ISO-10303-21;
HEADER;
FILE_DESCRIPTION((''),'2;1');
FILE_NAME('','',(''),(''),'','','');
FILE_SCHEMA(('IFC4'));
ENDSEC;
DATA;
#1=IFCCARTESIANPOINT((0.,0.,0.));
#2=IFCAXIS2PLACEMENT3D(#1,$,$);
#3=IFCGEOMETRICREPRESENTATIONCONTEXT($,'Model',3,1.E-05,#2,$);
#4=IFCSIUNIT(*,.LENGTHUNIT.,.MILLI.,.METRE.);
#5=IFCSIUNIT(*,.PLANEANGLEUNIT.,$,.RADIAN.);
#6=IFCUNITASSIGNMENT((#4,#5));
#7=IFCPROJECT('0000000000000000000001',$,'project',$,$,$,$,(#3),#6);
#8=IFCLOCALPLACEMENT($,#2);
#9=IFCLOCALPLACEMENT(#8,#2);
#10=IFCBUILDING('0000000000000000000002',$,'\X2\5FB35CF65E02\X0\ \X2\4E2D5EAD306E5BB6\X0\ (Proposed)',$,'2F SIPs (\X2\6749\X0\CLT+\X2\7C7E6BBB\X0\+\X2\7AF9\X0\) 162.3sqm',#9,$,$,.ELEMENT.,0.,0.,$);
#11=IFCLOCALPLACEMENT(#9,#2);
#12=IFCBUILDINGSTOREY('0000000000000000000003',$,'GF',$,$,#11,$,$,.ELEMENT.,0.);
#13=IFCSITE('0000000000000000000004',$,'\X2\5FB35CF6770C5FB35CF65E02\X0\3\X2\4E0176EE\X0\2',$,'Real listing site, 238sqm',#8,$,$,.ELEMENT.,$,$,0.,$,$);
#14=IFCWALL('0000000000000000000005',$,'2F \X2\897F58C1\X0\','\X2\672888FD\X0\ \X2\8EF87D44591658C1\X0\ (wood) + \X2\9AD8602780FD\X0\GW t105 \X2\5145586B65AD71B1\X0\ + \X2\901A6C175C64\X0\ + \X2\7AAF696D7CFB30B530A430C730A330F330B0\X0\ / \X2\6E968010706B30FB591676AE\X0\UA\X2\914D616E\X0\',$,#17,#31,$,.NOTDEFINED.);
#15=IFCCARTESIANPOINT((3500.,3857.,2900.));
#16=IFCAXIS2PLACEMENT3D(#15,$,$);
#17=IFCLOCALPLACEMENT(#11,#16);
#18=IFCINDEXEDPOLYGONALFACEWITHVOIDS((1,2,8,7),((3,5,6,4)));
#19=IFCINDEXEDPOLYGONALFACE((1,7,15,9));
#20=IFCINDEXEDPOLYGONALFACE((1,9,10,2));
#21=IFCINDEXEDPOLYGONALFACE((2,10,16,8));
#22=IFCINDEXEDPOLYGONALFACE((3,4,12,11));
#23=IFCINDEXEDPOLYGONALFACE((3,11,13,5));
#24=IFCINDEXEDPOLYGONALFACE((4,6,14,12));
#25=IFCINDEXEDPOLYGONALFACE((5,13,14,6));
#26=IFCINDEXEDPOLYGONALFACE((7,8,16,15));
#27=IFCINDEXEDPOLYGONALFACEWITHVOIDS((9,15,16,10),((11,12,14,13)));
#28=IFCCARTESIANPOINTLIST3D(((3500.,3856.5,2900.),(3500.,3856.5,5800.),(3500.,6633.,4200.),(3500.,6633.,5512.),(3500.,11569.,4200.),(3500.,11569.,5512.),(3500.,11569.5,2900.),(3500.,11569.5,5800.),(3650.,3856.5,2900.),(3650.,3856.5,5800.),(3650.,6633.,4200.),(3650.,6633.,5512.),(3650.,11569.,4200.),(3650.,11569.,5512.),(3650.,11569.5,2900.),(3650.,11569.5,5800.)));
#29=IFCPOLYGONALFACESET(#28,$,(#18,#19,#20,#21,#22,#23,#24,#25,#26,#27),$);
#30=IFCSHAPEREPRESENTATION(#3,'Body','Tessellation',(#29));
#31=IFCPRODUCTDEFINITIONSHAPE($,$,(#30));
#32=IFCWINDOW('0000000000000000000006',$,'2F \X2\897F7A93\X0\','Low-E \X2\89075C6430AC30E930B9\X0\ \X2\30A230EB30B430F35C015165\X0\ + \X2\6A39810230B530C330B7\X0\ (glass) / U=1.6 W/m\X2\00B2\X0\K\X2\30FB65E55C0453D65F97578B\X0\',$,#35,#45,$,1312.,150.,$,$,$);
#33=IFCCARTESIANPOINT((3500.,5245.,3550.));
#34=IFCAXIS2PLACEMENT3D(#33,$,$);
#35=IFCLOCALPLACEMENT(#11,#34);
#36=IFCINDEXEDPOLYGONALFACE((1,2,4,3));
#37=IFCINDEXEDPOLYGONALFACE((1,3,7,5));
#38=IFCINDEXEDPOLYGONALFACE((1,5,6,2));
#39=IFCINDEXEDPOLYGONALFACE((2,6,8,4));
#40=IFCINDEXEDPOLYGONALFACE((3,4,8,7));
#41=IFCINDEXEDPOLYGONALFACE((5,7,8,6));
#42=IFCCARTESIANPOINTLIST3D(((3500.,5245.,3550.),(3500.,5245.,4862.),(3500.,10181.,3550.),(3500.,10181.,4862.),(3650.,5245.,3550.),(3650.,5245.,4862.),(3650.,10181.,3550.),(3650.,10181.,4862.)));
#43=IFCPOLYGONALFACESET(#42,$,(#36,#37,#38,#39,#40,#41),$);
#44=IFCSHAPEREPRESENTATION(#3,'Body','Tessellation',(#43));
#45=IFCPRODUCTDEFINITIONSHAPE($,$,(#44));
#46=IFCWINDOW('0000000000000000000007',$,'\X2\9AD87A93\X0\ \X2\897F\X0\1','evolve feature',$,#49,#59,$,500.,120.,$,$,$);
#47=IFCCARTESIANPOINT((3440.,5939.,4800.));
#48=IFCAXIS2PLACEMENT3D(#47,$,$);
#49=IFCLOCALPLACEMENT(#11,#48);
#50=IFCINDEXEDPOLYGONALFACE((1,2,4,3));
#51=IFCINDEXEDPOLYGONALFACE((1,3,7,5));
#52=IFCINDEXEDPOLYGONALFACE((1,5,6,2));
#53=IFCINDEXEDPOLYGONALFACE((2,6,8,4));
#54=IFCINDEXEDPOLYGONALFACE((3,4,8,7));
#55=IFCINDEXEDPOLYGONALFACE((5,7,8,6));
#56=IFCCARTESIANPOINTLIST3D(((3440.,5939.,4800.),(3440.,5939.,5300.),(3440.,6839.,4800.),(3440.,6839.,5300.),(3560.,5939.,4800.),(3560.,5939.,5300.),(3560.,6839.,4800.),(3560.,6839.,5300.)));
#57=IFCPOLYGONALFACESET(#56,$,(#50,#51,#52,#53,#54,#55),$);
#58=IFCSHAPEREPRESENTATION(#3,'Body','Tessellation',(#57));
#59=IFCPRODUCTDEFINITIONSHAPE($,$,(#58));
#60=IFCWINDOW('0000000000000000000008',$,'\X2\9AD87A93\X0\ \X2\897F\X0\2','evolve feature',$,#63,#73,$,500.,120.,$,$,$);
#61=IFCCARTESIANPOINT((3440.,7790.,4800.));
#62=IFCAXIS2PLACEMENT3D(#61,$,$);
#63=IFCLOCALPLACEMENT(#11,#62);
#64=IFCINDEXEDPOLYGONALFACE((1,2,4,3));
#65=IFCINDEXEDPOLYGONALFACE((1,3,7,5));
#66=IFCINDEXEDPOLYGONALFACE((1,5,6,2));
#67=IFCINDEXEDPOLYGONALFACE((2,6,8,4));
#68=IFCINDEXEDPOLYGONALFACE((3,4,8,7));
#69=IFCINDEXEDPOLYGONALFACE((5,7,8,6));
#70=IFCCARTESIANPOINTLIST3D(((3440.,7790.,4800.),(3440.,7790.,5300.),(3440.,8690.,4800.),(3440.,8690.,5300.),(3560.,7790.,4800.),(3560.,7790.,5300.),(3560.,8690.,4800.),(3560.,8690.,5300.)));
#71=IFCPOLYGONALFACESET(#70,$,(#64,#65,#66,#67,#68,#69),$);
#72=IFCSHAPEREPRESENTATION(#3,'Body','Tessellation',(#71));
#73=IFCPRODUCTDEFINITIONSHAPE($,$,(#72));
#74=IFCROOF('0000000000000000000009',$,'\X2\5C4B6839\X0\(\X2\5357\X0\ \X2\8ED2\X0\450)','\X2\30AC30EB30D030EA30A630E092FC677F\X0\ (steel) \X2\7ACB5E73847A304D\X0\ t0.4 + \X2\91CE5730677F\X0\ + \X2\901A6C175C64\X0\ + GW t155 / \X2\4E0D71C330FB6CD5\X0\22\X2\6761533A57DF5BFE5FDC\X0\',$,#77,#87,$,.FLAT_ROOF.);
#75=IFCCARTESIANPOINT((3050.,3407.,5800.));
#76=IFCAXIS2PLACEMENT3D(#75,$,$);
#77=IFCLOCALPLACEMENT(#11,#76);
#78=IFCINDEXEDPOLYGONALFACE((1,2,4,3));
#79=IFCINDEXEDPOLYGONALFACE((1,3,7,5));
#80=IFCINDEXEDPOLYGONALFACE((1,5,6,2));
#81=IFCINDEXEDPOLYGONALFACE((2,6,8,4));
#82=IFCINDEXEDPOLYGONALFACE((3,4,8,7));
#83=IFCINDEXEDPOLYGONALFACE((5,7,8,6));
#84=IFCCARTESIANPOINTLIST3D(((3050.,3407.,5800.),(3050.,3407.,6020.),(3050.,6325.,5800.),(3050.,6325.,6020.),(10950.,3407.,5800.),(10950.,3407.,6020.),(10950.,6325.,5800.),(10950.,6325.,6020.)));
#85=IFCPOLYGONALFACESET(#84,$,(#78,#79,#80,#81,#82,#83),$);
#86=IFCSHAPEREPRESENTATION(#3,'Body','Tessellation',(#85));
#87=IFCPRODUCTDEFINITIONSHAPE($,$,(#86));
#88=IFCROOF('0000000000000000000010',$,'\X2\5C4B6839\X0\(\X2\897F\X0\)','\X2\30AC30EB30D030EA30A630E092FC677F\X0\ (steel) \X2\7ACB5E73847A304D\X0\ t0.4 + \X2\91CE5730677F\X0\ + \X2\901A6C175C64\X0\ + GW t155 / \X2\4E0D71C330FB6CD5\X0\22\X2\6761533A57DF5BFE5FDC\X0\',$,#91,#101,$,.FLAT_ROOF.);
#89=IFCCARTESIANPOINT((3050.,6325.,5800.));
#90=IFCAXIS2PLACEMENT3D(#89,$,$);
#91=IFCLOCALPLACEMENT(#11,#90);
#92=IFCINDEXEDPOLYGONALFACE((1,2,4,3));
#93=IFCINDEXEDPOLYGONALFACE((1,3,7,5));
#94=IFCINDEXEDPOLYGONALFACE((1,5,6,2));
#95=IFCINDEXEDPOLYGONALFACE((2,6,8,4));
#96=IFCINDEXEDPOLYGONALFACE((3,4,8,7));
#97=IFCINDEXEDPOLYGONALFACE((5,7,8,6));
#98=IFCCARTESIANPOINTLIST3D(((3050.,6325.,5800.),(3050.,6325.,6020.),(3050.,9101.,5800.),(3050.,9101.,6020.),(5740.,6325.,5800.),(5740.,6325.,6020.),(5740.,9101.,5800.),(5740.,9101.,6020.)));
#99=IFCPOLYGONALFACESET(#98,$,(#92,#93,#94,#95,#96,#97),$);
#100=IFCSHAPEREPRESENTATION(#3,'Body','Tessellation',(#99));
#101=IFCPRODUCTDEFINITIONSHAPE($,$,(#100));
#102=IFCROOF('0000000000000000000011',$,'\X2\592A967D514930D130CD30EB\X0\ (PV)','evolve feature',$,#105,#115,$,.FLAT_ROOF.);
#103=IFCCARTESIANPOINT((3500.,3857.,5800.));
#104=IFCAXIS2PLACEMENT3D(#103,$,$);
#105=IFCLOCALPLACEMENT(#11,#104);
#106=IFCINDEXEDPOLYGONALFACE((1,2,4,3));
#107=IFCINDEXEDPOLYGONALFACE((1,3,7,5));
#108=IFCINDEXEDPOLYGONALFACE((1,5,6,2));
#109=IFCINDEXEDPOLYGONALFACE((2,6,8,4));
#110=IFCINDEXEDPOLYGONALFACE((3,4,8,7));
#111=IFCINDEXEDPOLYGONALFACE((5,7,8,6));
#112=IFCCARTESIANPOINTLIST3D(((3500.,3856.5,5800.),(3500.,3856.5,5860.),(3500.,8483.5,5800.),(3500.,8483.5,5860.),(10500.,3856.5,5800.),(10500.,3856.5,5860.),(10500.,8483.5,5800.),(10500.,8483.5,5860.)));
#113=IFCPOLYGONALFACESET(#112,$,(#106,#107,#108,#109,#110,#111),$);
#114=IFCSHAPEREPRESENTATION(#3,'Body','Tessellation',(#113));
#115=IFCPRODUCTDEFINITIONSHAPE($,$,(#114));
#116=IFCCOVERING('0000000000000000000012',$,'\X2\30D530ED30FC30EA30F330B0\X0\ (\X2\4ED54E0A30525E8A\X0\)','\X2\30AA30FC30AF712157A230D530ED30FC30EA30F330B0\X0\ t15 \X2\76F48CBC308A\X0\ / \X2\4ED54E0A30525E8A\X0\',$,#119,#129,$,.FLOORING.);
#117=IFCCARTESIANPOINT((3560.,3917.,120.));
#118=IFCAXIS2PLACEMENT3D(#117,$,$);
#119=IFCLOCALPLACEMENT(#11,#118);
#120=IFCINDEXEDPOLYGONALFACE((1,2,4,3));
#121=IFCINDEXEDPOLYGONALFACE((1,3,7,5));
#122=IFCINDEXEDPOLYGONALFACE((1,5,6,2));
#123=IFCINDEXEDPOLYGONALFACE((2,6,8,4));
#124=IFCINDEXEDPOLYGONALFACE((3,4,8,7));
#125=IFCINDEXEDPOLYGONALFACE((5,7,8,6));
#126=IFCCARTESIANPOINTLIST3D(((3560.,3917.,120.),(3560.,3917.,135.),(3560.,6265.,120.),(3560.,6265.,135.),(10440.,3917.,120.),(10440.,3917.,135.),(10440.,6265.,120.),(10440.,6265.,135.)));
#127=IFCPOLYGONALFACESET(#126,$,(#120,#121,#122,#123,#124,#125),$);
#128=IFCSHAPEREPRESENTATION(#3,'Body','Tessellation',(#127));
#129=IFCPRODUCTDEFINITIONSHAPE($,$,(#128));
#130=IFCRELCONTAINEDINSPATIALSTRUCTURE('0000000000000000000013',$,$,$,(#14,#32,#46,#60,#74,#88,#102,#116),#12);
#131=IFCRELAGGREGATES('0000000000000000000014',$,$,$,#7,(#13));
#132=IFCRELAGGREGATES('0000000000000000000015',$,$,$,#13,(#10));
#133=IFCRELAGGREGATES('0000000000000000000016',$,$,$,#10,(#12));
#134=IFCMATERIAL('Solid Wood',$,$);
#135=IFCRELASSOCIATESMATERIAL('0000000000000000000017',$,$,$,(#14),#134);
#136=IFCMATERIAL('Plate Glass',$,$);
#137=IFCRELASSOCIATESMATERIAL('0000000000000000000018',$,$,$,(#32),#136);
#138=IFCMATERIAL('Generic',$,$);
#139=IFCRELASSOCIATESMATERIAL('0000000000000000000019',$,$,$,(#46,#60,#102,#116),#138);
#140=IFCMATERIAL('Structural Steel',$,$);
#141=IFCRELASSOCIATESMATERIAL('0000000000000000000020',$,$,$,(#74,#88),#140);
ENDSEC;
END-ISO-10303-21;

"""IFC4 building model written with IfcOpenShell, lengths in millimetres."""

from ifc_helpers import new_model, si_unit, frame, frame_2d, origin, place, context, project, spatial, rectangle, extrude, material, element, fill, save


model = new_model("IFC4")

# Units and contexts
model_context = context("Model", 3, precision=1e-05, world=origin())
ifc_project = project(units=[si_unit("LENGTHUNIT", "METRE", prefix="MILLI"), si_unit("PLANEANGLEUNIT", "RADIAN")], contexts=[model_context])

# Site, building, storey
site_placement = place(None, origin())
site = spatial("IfcSite", under=ifc_project, at=site_placement, Name="徳島県徳島市3丁目2", ObjectType="Real listing site, 238sqm", CompositionType="ELEMENT", RefElevation=0.0)
building_placement = place(site_placement, origin())
building = spatial("IfcBuilding", under=site, at=building_placement, Name="徳島市 中庭の家 (Proposed)", ObjectType="2F SIPs (杉CLT+籾殻+竹) 162.3sqm", CompositionType="ELEMENT", ElevationOfRefHeight=0.0, ElevationOfTerrain=0.0)
storey_placement = place(building_placement, origin())
storey = spatial("IfcBuildingStorey", under=building, at=storey_placement, Name="GF", CompositionType="ELEMENT", Elevation=0.0)

# Shared definitions
ifc_material_1 = material(Name="Solid Wood")
ifc_material_2 = material(Name="Generic")

# Shared definitions
ifc_material_3 = material(Name="Plate Glass")

# Wall, openings, windows
wall_1_placement = place(storey_placement, frame((3500.0, 3857.0, 2900.0)))
wall_1 = element("IfcWall", 1, at=wall_1_placement, inside=storey, material=ifc_material_1, Name="2F 西壁", Description="木製 軸組外壁 (wood) + 高性能GW t105 充填断熱 + 通気層 + 窯業系サイディング / 準耐火・外皮UA配慮", PredefinedType="NOTDEFINED", context=model_context, shape_type="SweptSolid", body=[
    extrude(rectangle(XDim=150.0, YDim=7713.0, at=frame_2d((75.0, 3856.0))), frame((3500.0, 3857.0, 2900.0)), (0.0, 0.0, 1.0), 2900.0),
])
opening_1_placement = place(storey_placement, frame((3500.0, 5245.0, 3550.0)))
opening_1 = element("IfcOpeningElement", 2, at=opening_1_placement, cuts=wall_1, PredefinedType="NOTDEFINED", context=model_context, shape_type="SweptSolid", body=[
    extrude(rectangle(XDim=150.0, YDim=4936.0, at=frame_2d((75.0, 2468.0))), frame((3500.0, 5245.0, 3550.0)), (0.0, 0.0, 1.0), 1312.0),
])
opening_2_placement = place(storey_placement, frame((3440.0, 5939.0, 4800.0)))
opening_2 = element("IfcOpeningElement", 3, at=opening_2_placement, cuts=wall_1, PredefinedType="NOTDEFINED", context=model_context, shape_type="SweptSolid", body=[
    extrude(rectangle(XDim=120.0, YDim=900.0, at=frame_2d((60.0, 450.0))), frame((3440.0, 5939.0, 4800.0)), (0.0, 0.0, 1.0), 500.0),
])
opening_3_placement = place(storey_placement, frame((3440.0, 7790.0, 4800.0)))
opening_3 = element("IfcOpeningElement", 4, at=opening_3_placement, cuts=wall_1, PredefinedType="NOTDEFINED", context=model_context, shape_type="SweptSolid", body=[
    extrude(rectangle(XDim=120.0, YDim=900.0, at=frame_2d((60.0, 450.0))), frame((3440.0, 7790.0, 4800.0)), (0.0, 0.0, 1.0), 500.0),
])
window_1_placement = place(storey_placement, frame((3500.0, 5245.0, 3550.0)))
window_1 = element("IfcWindow", 5, at=window_1_placement, inside=storey, material=ifc_material_3, Name="2F 西窓", Description="Low-E 複層ガラス アルゴン封入 + 樹脂サッシ (glass) / U=1.6 W/m²K・日射取得型", OverallHeight=1312.0, OverallWidth=150.0, context=model_context, shape_type="SweptSolid", body=[
    extrude(rectangle(XDim=150.0, YDim=4936.0, at=frame_2d((75.0, 2468.0))), frame((3500.0, 5245.0, 3550.0)), (0.0, 0.0, 1.0), 1312.0),
])
fill(opening_1, window_1)
window_2_placement = place(storey_placement, frame((3440.0, 5939.0, 4800.0)))
window_2 = element("IfcWindow", 6, at=window_2_placement, inside=storey, material=ifc_material_2, Name="高窓 西1", Description="evolve feature", OverallHeight=500.0, OverallWidth=120.0, context=model_context, shape_type="SweptSolid", body=[
    extrude(rectangle(XDim=120.0, YDim=900.0, at=frame_2d((60.0, 450.0))), frame((3440.0, 5939.0, 4800.0)), (0.0, 0.0, 1.0), 500.0),
])
fill(opening_2, window_2)
window_3_placement = place(storey_placement, frame((3440.0, 7790.0, 4800.0)))
window_3 = element("IfcWindow", 7, at=window_3_placement, inside=storey, material=ifc_material_2, Name="高窓 西2", Description="evolve feature", OverallHeight=500.0, OverallWidth=120.0, context=model_context, shape_type="SweptSolid", body=[
    extrude(rectangle(XDim=120.0, YDim=900.0, at=frame_2d((60.0, 450.0))), frame((3440.0, 7790.0, 4800.0)), (0.0, 0.0, 1.0), 500.0),
])
fill(opening_3, window_3)

# Roofs
ifc_material_4 = material(Name="Structural Steel")
roof_1_placement = place(storey_placement, frame((3050.0, 3407.0, 5800.0)))
element("IfcRoof", 8, at=roof_1_placement, inside=storey, material=ifc_material_4, Name="屋根(南 軒450)", Description="ガルバリウム鋼板 (steel) 立平葺き t0.4 + 野地板 + 通気層 + GW t155 / 不燃・法22条区域対応", PredefinedType="FLAT_ROOF", context=model_context, shape_type="SweptSolid", body=[
    extrude(rectangle(XDim=7900.0, YDim=2918.0, at=frame_2d((3950.0, 1459.0))), frame((3050.0, 3407.0, 5800.0)), (0.0, 0.0, 1.0), 220.0),
])
roof_2_placement = place(storey_placement, frame((3050.0, 6325.0, 5800.0)))
element("IfcRoof", 9, at=roof_2_placement, inside=storey, material=ifc_material_4, Name="屋根(西)", Description="ガルバリウム鋼板 (steel) 立平葺き t0.4 + 野地板 + 通気層 + GW t155 / 不燃・法22条区域対応", PredefinedType="FLAT_ROOF", context=model_context, shape_type="SweptSolid", body=[
    extrude(rectangle(XDim=2690.0, YDim=2776.0, at=frame_2d((1345.0, 1388.0))), frame((3050.0, 6325.0, 5800.0)), (0.0, 0.0, 1.0), 220.0),
])
roof_3_placement = place(storey_placement, frame((3500.0, 3857.0, 5800.0)))
element("IfcRoof", 10, at=roof_3_placement, inside=storey, material=ifc_material_2, Name="太陽光パネル (PV)", Description="evolve feature", PredefinedType="FLAT_ROOF", context=model_context, shape_type="SweptSolid", body=[
    extrude(rectangle(XDim=7000.0, YDim=4627.0, at=frame_2d((3500.0, 2313.0))), frame((3500.0, 3857.0, 5800.0)), (0.0, 0.0, 1.0), 60.0),
])

# Covering
covering_placement = place(storey_placement, frame((3560.0, 3917.0, 120.0)))
element("IfcCovering", 11, at=covering_placement, inside=storey, material=ifc_material_2, Name="フローリング (仕上げ床)", Description="オーク無垢フローリング t15 直貼り / 仕上げ床", PredefinedType="FLOORING", context=model_context, shape_type="SweptSolid", body=[
    extrude(rectangle(XDim=6880.0, YDim=2348.0, at=frame_2d((3440.0, 1174.0))), frame((3560.0, 3917.0, 120.0)), (0.0, 0.0, 1.0), 15.0),
])

save(model, "model.ifc")
